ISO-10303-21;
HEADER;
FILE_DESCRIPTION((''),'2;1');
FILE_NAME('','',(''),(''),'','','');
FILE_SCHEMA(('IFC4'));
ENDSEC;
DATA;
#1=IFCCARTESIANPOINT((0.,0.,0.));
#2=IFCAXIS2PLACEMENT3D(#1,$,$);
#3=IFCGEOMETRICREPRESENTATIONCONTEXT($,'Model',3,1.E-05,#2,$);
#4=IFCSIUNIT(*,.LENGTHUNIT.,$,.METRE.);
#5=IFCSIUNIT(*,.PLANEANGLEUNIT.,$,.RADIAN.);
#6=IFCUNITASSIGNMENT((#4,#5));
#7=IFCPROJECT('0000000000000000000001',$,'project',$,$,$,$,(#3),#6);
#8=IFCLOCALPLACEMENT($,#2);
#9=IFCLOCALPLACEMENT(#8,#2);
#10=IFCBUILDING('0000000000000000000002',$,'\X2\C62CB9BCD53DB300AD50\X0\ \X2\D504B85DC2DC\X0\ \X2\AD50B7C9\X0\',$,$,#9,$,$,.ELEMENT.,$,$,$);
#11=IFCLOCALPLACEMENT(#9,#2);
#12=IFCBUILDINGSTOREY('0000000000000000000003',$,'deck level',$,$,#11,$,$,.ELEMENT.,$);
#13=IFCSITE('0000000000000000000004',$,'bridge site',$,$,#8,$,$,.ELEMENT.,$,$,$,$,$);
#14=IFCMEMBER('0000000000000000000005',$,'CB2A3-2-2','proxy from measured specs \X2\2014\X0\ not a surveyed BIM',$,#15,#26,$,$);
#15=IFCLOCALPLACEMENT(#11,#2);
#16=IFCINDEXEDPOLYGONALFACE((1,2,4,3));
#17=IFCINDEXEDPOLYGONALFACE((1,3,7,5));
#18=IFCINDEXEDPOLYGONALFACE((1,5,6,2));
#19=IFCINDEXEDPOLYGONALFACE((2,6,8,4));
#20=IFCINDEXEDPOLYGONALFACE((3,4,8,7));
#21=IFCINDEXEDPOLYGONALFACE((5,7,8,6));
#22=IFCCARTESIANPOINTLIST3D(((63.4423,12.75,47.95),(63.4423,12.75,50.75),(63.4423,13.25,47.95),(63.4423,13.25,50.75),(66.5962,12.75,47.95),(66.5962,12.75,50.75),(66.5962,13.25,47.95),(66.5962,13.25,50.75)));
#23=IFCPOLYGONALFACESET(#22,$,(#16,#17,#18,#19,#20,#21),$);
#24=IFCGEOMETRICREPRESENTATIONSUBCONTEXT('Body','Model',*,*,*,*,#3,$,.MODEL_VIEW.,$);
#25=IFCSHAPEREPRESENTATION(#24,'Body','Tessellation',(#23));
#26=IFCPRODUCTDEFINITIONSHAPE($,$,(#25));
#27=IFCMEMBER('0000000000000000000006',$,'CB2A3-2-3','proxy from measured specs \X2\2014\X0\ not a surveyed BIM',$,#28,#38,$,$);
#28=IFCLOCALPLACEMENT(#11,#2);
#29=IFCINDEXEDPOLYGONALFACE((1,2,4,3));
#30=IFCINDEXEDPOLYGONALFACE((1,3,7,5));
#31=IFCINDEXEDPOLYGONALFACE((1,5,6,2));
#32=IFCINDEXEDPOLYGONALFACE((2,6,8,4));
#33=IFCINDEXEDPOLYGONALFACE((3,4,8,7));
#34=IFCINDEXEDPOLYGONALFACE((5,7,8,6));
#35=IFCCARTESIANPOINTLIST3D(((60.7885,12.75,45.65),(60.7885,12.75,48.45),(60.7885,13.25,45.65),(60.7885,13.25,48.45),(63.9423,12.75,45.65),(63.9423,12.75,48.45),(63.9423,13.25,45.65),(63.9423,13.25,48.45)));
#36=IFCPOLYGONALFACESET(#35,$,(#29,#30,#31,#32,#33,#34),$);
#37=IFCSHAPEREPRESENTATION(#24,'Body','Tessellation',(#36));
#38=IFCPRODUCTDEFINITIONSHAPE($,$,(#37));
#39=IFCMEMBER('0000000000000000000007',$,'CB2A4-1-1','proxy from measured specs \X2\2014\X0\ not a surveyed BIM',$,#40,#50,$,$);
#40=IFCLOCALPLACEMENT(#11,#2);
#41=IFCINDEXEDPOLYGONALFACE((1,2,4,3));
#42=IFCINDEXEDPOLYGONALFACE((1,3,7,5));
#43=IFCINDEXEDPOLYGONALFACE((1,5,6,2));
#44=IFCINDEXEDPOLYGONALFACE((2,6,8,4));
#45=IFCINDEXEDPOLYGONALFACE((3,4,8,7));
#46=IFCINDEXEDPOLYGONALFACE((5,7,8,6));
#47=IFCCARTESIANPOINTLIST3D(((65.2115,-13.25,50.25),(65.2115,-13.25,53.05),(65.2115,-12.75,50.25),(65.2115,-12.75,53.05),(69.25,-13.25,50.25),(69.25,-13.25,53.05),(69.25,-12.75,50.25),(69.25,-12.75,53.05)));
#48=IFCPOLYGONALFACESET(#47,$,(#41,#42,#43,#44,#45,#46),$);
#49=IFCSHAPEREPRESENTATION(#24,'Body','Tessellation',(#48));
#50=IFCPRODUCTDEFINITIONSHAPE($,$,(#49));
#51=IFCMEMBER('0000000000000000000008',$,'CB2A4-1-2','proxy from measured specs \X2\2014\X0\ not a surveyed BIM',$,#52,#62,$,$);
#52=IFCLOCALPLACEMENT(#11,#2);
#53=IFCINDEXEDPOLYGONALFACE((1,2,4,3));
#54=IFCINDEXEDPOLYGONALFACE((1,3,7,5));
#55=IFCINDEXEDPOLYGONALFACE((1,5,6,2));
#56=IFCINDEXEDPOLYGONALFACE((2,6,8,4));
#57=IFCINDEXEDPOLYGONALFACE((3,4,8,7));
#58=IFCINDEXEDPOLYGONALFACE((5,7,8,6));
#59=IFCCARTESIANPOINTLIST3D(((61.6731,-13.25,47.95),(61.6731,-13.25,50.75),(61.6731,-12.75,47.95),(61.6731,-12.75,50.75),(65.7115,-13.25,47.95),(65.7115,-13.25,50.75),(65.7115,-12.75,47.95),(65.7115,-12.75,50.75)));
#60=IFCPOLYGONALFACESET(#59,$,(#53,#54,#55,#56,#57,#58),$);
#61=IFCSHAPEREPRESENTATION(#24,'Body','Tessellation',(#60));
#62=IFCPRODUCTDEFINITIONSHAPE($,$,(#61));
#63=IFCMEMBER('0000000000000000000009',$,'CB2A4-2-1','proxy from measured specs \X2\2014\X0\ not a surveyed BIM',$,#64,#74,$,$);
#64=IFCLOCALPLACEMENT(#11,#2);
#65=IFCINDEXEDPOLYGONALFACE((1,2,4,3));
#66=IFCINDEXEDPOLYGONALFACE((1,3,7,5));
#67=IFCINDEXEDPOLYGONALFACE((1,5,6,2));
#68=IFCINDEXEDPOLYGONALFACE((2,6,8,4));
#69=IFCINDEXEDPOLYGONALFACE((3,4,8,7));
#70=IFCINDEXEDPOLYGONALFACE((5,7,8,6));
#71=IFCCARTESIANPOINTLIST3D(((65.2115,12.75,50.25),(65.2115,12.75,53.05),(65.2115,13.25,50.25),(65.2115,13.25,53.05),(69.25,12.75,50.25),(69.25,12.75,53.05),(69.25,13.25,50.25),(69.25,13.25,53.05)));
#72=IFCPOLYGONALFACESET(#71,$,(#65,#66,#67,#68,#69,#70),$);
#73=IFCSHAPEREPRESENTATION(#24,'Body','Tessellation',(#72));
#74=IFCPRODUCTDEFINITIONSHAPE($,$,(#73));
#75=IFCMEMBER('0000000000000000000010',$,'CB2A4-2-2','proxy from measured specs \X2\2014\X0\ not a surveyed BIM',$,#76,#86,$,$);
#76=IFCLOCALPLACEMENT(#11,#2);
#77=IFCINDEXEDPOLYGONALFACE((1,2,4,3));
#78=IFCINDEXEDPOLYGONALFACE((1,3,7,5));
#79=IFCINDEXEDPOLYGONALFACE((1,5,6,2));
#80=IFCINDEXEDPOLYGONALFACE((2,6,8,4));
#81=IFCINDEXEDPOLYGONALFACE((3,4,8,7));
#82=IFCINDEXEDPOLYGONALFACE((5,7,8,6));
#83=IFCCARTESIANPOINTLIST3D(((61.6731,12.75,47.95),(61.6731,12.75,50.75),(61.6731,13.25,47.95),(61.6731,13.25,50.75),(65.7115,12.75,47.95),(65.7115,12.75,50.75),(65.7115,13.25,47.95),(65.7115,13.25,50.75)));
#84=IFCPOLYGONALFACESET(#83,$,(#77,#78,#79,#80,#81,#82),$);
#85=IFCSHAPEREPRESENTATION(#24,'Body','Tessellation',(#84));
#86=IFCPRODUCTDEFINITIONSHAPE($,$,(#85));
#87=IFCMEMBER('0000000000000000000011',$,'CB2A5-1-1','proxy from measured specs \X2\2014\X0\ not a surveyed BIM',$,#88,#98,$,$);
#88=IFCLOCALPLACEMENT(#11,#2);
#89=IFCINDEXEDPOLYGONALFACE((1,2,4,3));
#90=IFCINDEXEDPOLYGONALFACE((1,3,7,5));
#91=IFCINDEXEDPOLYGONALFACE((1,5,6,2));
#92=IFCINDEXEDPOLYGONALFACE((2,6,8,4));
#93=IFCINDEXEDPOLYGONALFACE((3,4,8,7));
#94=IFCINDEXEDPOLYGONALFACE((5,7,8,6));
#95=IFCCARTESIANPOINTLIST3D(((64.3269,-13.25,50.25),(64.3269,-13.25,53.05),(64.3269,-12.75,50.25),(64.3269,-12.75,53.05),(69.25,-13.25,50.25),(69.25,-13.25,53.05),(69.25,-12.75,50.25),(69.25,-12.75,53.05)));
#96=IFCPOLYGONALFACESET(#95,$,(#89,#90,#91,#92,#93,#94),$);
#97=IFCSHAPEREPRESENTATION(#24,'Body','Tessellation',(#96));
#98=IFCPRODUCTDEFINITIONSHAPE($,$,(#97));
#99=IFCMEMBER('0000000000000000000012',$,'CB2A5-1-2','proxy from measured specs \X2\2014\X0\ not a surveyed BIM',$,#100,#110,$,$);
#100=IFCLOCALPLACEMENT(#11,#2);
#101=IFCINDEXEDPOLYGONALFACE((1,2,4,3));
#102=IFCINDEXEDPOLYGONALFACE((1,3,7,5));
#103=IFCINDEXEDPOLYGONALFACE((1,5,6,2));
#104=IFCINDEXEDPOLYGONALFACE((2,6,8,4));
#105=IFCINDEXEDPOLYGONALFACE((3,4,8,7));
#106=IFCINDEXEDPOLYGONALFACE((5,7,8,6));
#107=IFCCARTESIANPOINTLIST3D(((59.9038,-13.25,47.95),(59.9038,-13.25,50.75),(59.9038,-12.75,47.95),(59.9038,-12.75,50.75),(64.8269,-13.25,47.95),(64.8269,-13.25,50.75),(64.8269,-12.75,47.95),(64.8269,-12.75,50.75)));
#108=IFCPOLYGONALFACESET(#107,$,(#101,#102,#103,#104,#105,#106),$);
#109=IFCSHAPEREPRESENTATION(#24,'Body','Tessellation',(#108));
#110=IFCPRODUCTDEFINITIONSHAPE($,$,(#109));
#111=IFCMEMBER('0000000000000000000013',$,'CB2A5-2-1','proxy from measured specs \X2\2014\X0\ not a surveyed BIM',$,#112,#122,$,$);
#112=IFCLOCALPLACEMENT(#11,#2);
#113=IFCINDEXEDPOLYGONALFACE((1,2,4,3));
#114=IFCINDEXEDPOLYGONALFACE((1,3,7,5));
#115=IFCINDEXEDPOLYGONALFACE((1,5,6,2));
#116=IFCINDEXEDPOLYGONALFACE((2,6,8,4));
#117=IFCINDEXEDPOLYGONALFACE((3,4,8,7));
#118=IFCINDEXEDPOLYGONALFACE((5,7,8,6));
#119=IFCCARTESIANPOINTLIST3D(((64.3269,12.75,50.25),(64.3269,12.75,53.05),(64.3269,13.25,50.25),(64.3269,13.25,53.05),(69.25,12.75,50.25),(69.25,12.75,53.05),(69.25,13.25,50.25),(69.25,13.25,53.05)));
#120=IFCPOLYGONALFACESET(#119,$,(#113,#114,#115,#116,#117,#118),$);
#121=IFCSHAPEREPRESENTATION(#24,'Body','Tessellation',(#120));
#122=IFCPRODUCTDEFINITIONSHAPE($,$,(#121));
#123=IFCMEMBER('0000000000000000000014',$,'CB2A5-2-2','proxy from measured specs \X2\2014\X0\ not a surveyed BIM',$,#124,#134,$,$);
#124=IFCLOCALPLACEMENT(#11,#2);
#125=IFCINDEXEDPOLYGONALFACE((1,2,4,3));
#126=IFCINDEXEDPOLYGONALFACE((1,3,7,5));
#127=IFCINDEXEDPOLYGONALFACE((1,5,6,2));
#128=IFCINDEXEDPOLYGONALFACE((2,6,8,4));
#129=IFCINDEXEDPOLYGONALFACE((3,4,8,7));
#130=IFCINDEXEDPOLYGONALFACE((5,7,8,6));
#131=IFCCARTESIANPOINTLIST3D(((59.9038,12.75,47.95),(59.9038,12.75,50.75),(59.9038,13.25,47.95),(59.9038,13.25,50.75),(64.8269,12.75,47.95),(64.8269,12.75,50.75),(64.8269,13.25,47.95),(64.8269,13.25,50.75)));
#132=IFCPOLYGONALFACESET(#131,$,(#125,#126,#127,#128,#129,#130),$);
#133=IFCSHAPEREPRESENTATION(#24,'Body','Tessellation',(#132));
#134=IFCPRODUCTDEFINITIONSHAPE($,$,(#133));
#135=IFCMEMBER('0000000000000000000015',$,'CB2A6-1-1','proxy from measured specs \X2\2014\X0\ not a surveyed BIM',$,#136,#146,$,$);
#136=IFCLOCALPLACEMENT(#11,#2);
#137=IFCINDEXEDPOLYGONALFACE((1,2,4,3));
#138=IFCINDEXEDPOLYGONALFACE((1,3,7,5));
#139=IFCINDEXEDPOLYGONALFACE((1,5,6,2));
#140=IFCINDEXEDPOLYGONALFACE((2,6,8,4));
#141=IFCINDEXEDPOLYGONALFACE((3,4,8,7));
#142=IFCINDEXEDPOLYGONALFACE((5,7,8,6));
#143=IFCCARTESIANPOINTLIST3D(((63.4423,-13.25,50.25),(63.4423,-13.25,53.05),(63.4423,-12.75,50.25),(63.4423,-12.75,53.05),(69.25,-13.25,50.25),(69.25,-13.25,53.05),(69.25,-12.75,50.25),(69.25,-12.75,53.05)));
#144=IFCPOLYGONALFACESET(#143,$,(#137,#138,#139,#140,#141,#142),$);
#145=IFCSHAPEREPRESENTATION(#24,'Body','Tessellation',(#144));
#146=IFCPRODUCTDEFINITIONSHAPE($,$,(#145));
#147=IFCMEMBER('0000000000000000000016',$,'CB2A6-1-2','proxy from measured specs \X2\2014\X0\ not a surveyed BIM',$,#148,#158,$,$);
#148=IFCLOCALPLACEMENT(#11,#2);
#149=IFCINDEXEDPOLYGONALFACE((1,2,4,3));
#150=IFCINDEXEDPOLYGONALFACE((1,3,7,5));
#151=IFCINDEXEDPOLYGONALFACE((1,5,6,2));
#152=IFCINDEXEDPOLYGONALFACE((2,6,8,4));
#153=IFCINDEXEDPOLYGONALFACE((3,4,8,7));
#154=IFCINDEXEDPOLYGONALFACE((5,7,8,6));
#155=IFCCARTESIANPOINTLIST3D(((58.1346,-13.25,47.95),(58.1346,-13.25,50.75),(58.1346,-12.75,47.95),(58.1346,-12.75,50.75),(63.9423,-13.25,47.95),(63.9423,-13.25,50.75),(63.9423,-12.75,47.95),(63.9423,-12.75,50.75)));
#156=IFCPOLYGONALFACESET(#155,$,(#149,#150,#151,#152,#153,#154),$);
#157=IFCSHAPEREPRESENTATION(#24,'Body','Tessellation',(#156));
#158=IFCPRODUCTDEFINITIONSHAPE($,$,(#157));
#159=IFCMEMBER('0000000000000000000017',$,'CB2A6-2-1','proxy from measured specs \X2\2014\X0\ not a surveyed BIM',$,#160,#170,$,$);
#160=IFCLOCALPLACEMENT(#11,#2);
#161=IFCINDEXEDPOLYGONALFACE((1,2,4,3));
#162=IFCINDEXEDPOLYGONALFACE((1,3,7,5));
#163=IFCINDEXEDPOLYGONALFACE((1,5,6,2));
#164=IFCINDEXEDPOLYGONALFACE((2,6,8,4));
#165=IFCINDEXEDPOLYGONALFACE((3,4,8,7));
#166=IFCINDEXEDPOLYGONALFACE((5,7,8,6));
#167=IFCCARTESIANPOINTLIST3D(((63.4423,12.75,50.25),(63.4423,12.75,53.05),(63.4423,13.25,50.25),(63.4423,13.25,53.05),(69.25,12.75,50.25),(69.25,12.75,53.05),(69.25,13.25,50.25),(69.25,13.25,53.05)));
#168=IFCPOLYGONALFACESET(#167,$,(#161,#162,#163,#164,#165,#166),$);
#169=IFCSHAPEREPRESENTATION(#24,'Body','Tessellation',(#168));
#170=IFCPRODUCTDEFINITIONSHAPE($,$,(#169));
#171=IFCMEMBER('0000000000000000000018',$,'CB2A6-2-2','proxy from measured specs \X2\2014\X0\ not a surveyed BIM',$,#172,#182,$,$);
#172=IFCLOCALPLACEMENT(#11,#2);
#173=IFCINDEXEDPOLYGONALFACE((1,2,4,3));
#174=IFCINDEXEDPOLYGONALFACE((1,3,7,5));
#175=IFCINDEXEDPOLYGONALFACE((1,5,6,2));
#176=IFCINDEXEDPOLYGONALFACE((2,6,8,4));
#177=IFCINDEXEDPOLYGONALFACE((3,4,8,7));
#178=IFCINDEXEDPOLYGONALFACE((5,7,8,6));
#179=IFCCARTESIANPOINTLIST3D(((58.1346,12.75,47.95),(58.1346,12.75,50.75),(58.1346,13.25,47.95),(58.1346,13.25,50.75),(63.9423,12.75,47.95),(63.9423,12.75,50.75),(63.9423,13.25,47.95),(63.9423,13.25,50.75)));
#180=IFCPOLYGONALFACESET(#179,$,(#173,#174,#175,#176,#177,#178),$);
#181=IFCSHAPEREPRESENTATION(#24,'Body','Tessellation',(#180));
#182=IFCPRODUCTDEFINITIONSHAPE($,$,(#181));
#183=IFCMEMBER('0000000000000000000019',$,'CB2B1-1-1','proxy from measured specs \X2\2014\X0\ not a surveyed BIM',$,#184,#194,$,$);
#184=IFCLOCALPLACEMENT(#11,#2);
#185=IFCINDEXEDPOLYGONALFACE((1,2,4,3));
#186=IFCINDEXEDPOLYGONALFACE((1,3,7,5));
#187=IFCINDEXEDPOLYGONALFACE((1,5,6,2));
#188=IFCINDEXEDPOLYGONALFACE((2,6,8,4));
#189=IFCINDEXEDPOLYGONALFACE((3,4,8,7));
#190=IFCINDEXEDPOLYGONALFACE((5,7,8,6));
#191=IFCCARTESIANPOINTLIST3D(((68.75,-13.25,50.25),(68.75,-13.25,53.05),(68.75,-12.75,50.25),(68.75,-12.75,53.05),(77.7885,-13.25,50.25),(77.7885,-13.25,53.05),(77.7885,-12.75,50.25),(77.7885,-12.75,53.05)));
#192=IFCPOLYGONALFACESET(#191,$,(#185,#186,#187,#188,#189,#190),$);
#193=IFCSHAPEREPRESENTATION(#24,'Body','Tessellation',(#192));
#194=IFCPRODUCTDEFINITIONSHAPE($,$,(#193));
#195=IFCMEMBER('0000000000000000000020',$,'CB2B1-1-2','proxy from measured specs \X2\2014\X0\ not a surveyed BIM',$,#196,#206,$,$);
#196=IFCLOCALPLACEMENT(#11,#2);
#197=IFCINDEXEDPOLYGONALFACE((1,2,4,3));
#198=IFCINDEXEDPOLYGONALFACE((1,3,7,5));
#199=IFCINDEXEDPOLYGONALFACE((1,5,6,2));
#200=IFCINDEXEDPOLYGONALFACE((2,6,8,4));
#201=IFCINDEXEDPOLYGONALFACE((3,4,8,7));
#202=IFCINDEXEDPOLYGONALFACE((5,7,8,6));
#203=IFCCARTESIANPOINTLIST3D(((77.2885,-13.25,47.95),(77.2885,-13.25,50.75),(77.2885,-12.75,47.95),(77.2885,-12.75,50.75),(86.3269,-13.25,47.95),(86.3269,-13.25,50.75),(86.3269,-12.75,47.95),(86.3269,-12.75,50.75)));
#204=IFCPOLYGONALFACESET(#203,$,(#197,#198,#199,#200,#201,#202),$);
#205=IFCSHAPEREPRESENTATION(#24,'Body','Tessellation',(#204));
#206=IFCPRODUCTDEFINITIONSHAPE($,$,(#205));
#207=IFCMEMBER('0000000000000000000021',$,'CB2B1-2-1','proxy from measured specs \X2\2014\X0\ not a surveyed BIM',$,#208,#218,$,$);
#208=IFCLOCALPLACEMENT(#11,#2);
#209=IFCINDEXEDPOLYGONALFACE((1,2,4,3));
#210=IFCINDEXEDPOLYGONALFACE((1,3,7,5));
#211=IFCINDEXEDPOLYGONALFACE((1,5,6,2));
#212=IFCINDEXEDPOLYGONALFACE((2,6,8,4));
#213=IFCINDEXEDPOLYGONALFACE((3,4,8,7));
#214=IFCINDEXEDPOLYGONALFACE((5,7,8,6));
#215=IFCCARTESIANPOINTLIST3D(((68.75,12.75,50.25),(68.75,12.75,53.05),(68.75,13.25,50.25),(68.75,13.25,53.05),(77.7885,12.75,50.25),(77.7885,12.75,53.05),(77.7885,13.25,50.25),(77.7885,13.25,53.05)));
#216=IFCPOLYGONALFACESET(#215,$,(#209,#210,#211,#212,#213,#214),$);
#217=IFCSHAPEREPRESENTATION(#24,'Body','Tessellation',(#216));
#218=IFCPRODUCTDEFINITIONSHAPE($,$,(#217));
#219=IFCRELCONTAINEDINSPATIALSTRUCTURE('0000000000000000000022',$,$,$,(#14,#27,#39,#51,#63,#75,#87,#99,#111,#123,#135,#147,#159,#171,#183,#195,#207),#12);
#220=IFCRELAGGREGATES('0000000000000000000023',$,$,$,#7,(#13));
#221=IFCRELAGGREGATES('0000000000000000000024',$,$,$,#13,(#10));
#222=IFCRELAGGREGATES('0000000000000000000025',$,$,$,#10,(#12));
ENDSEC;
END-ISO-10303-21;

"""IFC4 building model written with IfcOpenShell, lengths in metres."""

from ifc_helpers import new_model, si_unit, frame, origin, origin_2d, place, context, subcontext, project, spatial, rectangle, extrude, element, save


model = new_model("IFC4")

# Units and contexts
model_context = context("Model", 3, precision=1e-05, world=origin())
body_context = subcontext(model_context, "Body", "Model", "MODEL_VIEW")
ifc_project = project(units=[si_unit("LENGTHUNIT", "METRE"), si_unit("PLANEANGLEUNIT", "RADIAN")], contexts=[model_context])

# Site, building, storey
site_placement = place(None, origin())
site = spatial("IfcSite", under=ifc_project, at=site_placement, Name="bridge site", CompositionType="ELEMENT")
building_placement = place(site_placement, origin())
building = spatial("IfcBuilding", under=site, at=building_placement, Name="올림픽대교 프록시 교량", CompositionType="ELEMENT")
storey_placement = place(building_placement, origin())
storey = spatial("IfcBuildingStorey", under=building, at=storey_placement, Name="deck level", CompositionType="ELEMENT")

# Members
member_1_placement = place(storey_placement, frame((65.0192, 13.0, 47.95)))
element("IfcMember", 1, at=member_1_placement, inside=storey, Name="CB2A3-2-2", Description="proxy from measured specs — not a surveyed BIM", context=body_context, shape_type="SweptSolid", body=[
    extrude(rectangle(XDim=3.1538, YDim=0.5, at=origin_2d()), origin(), (0.0, 0.0, 1.0), 2.8),
])
member_2_placement = place(storey_placement, frame((62.3654, 13.0, 45.65)))
element("IfcMember", 2, at=member_2_placement, inside=storey, Name="CB2A3-2-3", Description="proxy from measured specs — not a surveyed BIM", context=body_context, shape_type="SweptSolid", body=[
    extrude(rectangle(XDim=3.1538, YDim=0.5, at=origin_2d()), origin(), (0.0, 0.0, 1.0), 2.8),
])
member_3_placement = place(storey_placement, frame((67.2308, -13.0, 50.25)))
element("IfcMember", 3, at=member_3_placement, inside=storey, Name="CB2A4-1-1", Description="proxy from measured specs — not a surveyed BIM", context=body_context, shape_type="SweptSolid", body=[
    extrude(rectangle(XDim=4.0385, YDim=0.5, at=origin_2d()), origin(), (0.0, 0.0, 1.0), 2.8),
])
member_4_placement = place(storey_placement, frame((63.6923, -13.0, 47.95)))
element("IfcMember", 4, at=member_4_placement, inside=storey, Name="CB2A4-1-2", Description="proxy from measured specs — not a surveyed BIM", context=body_context, shape_type="SweptSolid", body=[
    extrude(rectangle(XDim=4.0385, YDim=0.5, at=origin_2d()), origin(), (0.0, 0.0, 1.0), 2.8),
])
member_5_placement = place(storey_placement, frame((67.2308, 13.0, 50.25)))
element("IfcMember", 5, at=member_5_placement, inside=storey, Name="CB2A4-2-1", Description="proxy from measured specs — not a surveyed BIM", context=body_context, shape_type="SweptSolid", body=[
    extrude(rectangle(XDim=4.0385, YDim=0.5, at=origin_2d()), origin(), (0.0, 0.0, 1.0), 2.8),
])
member_6_placement = place(storey_placement, frame((63.6923, 13.0, 47.95)))
element("IfcMember", 6, at=member_6_placement, inside=storey, Name="CB2A4-2-2", Description="proxy from measured specs — not a surveyed BIM", context=body_context, shape_type="SweptSolid", body=[
    extrude(rectangle(XDim=4.0385, YDim=0.5, at=origin_2d()), origin(), (0.0, 0.0, 1.0), 2.8),
])
member_7_placement = place(storey_placement, frame((66.7885, -13.0, 50.25)))
element("IfcMember", 7, at=member_7_placement, inside=storey, Name="CB2A5-1-1", Description="proxy from measured specs — not a surveyed BIM", context=body_context, shape_type="SweptSolid", body=[
    extrude(rectangle(XDim=4.9231, YDim=0.5, at=origin_2d()), origin(), (0.0, 0.0, 1.0), 2.8),
])
member_8_placement = place(storey_placement, frame((62.3654, -13.0, 47.95)))
element("IfcMember", 8, at=member_8_placement, inside=storey, Name="CB2A5-1-2", Description="proxy from measured specs — not a surveyed BIM", context=body_context, shape_type="SweptSolid", body=[
    extrude(rectangle(XDim=4.9231, YDim=0.5, at=origin_2d()), origin(), (0.0, 0.0, 1.0), 2.8),
])
member_9_placement = place(storey_placement, frame((66.7885, 13.0, 50.25)))
element("IfcMember", 9, at=member_9_placement, inside=storey, Name="CB2A5-2-1", Description="proxy from measured specs — not a surveyed BIM", context=body_context, shape_type="SweptSolid", body=[
    extrude(rectangle(XDim=4.9231, YDim=0.5, at=origin_2d()), origin(), (0.0, 0.0, 1.0), 2.8),
])
member_10_placement = place(storey_placement, frame((62.3654, 13.0, 47.95)))
element("IfcMember", 10, at=member_10_placement, inside=storey, Name="CB2A5-2-2", Description="proxy from measured specs — not a surveyed BIM", context=body_context, shape_type="SweptSolid", body=[
    extrude(rectangle(XDim=4.9231, YDim=0.5, at=origin_2d()), origin(), (0.0, 0.0, 1.0), 2.8),
])
member_11_placement = place(storey_placement, frame((66.3462, -13.0, 50.25)))
element("IfcMember", 11, at=member_11_placement, inside=storey, Name="CB2A6-1-1", Description="proxy from measured specs — not a surveyed BIM", context=body_context, shape_type="SweptSolid", body=[
    extrude(rectangle(XDim=5.8077, YDim=0.5, at=origin_2d()), origin(), (0.0, 0.0, 1.0), 2.8),
])
member_12_placement = place(storey_placement, frame((61.0385, -13.0, 47.95)))
element("IfcMember", 12, at=member_12_placement, inside=storey, Name="CB2A6-1-2", Description="proxy from measured specs — not a surveyed BIM", context=body_context, shape_type="SweptSolid", body=[
    extrude(rectangle(XDim=5.8077, YDim=0.5, at=origin_2d()), origin(), (0.0, 0.0, 1.0), 2.8),
])
member_13_placement = place(storey_placement, frame((66.3462, 13.0, 50.25)))
element("IfcMember", 13, at=member_13_placement, inside=storey, Name="CB2A6-2-1", Description="proxy from measured specs — not a surveyed BIM", context=body_context, shape_type="SweptSolid", body=[
    extrude(rectangle(XDim=5.8077, YDim=0.5, at=origin_2d()), origin(), (0.0, 0.0, 1.0), 2.8),
])
member_14_placement = place(storey_placement, frame((61.0385, 13.0, 47.95)))
element("IfcMember", 14, at=member_14_placement, inside=storey, Name="CB2A6-2-2", Description="proxy from measured specs — not a surveyed BIM", context=body_context, shape_type="SweptSolid", body=[
    extrude(rectangle(XDim=5.8077, YDim=0.5, at=origin_2d()), origin(), (0.0, 0.0, 1.0), 2.8),
])
member_15_placement = place(storey_placement, frame((73.2692, -13.0, 50.25)))
element("IfcMember", 15, at=member_15_placement, inside=storey, Name="CB2B1-1-1", Description="proxy from measured specs — not a surveyed BIM", context=body_context, shape_type="SweptSolid", body=[
    extrude(rectangle(XDim=9.0385, YDim=0.5, at=origin_2d()), origin(), (0.0, 0.0, 1.0), 2.8),
])
member_16_placement = place(storey_placement, frame((81.8077, -13.0, 47.95)))
element("IfcMember", 16, at=member_16_placement, inside=storey, Name="CB2B1-1-2", Description="proxy from measured specs — not a surveyed BIM", context=body_context, shape_type="SweptSolid", body=[
    extrude(rectangle(XDim=9.0385, YDim=0.5, at=origin_2d()), origin(), (0.0, 0.0, 1.0), 2.8),
])
member_17_placement = place(storey_placement, frame((73.2692, 13.0, 50.25)))
element("IfcMember", 17, at=member_17_placement, inside=storey, Name="CB2B1-2-1", Description="proxy from measured specs — not a surveyed BIM", context=body_context, shape_type="SweptSolid", body=[
    extrude(rectangle(XDim=9.0385, YDim=0.5, at=origin_2d()), origin(), (0.0, 0.0, 1.0), 2.8),
])

save(model, "model.ifc")
